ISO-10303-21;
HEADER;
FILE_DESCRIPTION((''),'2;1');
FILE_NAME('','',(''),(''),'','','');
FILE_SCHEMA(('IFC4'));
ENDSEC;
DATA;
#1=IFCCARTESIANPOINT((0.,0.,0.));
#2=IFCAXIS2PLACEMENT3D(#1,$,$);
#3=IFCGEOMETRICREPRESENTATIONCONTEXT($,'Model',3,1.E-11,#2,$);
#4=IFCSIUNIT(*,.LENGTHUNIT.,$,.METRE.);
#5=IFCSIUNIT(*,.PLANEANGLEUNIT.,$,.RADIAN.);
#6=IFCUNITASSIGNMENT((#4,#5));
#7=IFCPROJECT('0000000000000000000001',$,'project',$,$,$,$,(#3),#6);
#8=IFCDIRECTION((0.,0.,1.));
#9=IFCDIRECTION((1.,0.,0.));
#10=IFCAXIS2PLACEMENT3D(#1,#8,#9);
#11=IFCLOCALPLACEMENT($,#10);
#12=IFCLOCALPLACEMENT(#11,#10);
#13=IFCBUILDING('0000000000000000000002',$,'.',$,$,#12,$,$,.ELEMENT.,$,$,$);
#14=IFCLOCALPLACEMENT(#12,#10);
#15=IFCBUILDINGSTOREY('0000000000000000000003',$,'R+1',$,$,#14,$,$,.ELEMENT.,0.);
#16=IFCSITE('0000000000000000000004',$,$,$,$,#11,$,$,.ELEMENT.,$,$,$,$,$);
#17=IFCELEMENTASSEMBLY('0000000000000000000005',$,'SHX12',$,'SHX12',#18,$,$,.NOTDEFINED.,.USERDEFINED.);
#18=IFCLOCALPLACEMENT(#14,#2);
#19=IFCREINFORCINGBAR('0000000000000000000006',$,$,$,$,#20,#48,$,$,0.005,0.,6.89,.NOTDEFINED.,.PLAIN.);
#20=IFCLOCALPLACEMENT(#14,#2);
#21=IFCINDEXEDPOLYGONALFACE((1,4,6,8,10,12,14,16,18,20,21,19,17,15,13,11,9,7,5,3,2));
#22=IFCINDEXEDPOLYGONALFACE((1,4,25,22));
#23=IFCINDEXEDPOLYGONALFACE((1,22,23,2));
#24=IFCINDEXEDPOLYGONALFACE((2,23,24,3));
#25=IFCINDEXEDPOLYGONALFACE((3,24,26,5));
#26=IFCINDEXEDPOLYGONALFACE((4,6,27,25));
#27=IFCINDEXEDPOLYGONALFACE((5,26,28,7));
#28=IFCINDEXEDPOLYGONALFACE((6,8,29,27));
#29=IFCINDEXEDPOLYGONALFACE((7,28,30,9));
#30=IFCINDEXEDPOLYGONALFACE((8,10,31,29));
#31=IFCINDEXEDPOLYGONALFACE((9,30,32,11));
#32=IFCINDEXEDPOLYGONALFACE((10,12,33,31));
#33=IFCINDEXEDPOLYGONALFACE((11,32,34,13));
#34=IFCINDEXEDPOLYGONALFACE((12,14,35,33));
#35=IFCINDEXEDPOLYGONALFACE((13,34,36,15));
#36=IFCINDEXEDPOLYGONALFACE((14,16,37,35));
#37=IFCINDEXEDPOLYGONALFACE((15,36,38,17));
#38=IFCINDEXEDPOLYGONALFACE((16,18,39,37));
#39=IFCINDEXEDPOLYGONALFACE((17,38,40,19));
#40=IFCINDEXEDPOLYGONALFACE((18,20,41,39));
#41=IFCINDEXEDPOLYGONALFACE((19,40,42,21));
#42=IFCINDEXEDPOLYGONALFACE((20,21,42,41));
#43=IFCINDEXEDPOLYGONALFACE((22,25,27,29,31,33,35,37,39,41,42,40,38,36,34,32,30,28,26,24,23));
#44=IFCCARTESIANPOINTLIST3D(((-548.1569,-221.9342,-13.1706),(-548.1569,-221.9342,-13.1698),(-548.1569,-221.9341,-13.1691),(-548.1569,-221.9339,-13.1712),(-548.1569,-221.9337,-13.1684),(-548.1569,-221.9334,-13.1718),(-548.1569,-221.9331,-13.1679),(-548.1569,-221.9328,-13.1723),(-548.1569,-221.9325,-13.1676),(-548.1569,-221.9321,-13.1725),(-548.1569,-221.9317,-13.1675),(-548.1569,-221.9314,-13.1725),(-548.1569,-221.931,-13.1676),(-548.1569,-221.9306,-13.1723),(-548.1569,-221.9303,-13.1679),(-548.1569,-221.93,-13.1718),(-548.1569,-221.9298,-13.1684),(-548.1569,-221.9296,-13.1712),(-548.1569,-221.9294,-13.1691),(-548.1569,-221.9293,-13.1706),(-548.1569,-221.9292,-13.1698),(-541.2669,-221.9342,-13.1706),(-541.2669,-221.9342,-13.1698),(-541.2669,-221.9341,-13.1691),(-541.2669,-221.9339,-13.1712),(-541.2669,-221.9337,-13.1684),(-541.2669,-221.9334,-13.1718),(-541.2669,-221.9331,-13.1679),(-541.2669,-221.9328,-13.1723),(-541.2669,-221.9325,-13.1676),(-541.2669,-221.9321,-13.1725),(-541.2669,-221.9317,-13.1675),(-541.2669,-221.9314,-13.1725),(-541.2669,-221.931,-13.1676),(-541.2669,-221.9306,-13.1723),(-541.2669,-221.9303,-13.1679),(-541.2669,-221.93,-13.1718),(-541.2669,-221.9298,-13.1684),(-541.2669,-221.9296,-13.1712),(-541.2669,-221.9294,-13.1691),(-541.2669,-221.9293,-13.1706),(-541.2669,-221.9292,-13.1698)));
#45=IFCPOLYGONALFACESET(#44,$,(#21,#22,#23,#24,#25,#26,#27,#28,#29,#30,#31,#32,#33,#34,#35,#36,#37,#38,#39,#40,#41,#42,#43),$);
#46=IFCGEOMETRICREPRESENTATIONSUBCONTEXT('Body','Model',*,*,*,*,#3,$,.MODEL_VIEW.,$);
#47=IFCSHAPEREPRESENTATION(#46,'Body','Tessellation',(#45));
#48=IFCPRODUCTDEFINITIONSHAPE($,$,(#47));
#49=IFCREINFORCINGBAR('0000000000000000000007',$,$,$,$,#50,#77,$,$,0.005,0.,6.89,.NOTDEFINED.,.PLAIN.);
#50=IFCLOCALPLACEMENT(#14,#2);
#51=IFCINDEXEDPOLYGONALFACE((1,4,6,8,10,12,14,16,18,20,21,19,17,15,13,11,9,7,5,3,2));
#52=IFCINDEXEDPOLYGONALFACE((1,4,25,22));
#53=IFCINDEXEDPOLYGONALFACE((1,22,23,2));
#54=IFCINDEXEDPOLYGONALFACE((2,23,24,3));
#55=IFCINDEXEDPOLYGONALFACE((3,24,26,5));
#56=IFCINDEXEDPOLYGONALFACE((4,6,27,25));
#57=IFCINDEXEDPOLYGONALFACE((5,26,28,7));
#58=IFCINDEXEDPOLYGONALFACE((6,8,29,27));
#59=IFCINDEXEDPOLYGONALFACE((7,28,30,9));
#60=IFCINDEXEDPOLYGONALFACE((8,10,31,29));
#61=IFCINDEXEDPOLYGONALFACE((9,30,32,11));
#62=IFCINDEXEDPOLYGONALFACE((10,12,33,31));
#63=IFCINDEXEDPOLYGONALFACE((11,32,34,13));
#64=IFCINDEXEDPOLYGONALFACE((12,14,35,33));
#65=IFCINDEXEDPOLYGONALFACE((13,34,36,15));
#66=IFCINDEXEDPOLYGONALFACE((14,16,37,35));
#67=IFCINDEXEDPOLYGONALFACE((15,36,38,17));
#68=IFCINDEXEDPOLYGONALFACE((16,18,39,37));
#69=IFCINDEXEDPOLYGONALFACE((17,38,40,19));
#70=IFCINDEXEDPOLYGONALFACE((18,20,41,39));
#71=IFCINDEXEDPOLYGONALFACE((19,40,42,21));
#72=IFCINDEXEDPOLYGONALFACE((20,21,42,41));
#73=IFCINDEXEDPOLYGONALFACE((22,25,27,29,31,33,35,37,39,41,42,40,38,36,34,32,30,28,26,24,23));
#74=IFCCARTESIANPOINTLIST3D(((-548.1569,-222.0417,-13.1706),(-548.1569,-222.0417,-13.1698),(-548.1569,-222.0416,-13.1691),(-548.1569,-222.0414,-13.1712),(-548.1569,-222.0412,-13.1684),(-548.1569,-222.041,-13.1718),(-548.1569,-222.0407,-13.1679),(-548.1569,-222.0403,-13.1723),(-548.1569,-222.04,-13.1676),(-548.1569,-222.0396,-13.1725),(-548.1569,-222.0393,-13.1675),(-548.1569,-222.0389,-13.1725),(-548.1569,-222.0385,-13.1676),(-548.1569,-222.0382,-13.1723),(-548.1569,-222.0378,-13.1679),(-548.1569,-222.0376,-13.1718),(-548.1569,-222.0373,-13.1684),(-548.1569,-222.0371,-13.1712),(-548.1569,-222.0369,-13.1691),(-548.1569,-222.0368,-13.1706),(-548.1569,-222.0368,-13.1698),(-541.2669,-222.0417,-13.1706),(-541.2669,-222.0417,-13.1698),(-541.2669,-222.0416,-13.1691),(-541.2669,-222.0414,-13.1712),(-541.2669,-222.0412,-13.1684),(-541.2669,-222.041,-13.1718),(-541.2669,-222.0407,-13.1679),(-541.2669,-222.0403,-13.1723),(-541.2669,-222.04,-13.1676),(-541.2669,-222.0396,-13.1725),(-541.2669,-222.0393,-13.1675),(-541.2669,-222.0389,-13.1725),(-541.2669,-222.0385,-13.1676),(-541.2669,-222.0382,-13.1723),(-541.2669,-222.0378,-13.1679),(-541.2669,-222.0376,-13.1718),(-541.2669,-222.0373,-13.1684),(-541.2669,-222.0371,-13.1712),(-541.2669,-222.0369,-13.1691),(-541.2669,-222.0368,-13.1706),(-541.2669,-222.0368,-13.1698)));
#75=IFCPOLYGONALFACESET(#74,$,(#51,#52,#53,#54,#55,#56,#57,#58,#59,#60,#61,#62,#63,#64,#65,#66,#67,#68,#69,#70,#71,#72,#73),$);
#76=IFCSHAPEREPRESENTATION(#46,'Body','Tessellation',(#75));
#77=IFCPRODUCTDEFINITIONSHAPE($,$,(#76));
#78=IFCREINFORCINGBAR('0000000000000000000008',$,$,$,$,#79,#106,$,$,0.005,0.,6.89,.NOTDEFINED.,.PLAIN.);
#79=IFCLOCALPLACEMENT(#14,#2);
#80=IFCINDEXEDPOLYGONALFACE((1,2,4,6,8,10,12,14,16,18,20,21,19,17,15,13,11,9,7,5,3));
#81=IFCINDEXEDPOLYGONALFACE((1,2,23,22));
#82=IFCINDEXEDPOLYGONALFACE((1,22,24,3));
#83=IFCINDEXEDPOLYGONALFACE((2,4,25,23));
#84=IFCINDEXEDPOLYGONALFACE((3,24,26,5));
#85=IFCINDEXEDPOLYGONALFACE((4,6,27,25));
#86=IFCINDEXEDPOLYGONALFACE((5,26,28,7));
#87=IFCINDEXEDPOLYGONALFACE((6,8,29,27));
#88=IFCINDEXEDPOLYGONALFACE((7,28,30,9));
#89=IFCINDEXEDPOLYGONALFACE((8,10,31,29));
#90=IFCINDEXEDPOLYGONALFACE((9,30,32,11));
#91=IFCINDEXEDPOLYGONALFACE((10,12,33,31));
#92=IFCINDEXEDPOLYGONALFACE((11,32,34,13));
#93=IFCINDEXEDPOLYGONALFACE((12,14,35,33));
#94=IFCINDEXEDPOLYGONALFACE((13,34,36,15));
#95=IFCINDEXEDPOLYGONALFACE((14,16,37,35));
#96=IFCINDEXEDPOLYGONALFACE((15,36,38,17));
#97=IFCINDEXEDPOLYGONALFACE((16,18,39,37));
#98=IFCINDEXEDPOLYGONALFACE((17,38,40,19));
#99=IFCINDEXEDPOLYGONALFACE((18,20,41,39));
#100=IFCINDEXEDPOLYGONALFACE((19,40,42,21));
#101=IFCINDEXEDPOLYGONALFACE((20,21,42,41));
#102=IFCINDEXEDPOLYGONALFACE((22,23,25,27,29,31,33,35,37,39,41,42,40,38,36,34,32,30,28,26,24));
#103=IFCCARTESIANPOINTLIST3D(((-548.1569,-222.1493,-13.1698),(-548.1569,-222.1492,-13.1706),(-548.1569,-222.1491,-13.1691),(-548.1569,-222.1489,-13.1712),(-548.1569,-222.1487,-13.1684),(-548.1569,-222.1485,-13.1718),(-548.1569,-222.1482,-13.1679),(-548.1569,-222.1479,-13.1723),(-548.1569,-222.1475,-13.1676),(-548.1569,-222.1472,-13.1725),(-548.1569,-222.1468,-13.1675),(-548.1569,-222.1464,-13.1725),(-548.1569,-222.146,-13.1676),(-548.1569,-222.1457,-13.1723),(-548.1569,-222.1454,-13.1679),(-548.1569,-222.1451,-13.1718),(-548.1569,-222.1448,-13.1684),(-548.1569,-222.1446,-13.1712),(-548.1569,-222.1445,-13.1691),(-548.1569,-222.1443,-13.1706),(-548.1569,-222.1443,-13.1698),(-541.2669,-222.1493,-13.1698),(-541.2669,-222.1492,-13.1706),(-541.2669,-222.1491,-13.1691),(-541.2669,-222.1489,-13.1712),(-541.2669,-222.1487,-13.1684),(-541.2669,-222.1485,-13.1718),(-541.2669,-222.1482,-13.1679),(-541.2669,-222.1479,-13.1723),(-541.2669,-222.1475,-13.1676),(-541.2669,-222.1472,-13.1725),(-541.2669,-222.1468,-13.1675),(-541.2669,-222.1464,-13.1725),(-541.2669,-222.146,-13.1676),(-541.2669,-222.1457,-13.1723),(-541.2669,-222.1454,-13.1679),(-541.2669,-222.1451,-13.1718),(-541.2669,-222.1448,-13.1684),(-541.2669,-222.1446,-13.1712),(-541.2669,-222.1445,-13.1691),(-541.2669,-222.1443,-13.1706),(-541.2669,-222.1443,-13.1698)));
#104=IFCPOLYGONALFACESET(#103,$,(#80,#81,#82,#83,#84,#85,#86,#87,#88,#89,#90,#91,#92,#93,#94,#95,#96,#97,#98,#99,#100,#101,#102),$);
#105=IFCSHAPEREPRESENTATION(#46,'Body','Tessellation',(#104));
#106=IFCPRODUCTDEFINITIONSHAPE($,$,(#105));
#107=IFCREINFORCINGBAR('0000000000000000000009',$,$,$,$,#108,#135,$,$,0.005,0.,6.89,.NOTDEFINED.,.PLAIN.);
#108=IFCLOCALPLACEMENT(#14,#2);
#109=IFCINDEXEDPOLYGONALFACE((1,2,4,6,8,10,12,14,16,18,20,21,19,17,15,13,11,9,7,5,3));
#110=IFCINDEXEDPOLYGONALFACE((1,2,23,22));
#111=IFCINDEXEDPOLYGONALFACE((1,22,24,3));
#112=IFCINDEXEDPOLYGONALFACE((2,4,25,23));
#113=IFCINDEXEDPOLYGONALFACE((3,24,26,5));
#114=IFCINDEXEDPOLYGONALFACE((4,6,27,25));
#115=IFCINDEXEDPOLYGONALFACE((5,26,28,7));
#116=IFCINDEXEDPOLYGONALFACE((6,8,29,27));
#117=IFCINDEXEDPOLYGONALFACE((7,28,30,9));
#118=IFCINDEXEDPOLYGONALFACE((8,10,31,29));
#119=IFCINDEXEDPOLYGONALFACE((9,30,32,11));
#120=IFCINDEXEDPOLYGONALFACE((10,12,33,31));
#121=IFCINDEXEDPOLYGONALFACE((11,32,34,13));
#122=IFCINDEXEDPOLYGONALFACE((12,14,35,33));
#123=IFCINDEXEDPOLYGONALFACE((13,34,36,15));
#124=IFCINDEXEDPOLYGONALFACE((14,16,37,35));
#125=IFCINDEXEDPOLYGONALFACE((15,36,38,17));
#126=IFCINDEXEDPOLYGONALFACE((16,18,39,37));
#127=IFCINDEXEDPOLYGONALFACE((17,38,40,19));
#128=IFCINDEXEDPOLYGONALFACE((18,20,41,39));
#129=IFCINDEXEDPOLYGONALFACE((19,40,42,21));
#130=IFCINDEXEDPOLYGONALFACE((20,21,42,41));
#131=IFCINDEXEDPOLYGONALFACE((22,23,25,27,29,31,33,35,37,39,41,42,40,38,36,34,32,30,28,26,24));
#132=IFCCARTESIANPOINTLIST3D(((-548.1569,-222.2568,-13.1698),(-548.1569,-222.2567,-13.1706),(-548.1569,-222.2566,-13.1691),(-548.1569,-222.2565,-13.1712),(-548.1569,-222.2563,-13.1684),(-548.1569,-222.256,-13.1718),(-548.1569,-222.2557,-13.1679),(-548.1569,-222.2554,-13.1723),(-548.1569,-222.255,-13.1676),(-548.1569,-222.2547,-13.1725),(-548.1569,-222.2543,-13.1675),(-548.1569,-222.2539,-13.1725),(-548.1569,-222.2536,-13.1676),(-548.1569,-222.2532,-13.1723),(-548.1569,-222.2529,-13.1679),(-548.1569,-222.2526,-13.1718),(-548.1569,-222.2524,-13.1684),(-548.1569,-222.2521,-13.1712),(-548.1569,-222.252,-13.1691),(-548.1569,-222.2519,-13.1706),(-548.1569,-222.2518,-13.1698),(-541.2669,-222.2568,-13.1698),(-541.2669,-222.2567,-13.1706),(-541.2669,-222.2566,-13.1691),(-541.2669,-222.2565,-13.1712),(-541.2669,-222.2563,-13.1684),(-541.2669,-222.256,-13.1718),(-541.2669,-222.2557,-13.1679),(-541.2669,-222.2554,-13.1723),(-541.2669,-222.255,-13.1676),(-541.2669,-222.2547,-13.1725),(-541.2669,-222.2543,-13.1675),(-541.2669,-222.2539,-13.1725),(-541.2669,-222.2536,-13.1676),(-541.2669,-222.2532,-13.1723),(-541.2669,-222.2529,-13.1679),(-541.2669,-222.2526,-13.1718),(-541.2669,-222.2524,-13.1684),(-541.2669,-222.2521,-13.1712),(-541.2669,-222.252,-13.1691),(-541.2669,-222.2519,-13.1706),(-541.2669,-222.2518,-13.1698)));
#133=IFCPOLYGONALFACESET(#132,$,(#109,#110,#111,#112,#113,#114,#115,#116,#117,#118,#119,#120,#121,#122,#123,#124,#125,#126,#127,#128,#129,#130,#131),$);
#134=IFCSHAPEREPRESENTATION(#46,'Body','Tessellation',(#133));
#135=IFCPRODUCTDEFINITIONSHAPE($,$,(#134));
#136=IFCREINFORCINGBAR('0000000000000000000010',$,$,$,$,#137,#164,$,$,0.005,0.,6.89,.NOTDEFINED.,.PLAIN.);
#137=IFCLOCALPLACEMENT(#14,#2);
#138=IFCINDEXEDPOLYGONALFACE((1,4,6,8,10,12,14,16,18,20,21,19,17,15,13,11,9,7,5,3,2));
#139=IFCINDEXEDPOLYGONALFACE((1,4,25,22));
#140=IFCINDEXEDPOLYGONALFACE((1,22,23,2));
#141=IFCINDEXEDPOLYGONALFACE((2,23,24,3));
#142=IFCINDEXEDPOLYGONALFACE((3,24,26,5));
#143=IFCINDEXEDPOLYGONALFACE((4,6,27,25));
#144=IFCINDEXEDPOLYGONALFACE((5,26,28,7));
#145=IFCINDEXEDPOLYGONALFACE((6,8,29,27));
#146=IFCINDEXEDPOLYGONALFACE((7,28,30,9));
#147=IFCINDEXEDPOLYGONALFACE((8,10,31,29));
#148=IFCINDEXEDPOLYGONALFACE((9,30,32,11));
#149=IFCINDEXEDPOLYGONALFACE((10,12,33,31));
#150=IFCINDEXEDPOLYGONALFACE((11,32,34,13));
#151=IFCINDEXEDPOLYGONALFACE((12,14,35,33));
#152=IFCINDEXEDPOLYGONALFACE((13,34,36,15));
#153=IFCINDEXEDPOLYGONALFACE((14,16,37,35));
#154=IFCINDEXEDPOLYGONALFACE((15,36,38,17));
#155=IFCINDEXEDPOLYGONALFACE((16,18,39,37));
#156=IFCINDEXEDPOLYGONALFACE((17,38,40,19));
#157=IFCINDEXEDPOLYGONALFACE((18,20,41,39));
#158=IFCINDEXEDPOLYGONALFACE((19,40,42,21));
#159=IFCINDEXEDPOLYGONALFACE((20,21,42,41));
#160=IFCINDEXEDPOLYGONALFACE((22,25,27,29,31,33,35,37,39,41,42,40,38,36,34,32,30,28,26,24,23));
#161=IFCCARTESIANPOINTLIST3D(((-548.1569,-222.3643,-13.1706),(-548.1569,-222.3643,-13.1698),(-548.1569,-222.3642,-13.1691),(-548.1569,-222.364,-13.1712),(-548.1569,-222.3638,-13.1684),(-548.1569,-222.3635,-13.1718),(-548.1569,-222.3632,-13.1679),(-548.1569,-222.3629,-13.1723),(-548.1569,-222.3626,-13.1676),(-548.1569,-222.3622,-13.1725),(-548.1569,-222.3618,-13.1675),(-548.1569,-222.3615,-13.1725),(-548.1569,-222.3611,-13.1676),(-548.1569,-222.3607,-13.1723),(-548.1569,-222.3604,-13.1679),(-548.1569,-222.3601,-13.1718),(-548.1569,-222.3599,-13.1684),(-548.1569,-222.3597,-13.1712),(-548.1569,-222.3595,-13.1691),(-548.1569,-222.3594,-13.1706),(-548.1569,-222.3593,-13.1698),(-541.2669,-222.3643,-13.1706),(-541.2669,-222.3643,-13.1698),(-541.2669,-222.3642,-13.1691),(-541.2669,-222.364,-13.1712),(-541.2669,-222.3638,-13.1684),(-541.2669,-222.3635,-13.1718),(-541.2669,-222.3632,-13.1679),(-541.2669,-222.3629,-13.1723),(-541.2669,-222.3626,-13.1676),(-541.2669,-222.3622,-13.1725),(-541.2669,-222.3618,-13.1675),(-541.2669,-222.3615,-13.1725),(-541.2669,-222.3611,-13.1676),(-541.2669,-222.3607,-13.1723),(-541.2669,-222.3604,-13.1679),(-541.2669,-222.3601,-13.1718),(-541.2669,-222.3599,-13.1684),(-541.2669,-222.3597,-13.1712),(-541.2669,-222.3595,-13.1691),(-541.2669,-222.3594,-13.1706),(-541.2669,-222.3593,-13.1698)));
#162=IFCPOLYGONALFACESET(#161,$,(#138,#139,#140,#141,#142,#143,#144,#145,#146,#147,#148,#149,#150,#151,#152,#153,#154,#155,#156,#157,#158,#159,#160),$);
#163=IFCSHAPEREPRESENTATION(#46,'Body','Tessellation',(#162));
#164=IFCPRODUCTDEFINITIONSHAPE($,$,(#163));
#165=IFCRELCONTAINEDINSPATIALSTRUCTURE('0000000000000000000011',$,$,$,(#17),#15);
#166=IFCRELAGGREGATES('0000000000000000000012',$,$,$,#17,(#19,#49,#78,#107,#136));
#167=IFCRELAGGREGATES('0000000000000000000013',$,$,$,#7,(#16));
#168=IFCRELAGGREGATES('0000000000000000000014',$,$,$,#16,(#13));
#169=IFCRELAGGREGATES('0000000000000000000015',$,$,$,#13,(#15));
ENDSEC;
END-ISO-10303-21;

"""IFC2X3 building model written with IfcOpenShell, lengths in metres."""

from ifc_helpers import new_model, entity, si_unit, origin, origin_with_axes, place, context, subcontext, project, spatial, shape, element, aggregate, save


model = new_model("IFC2X3")

# Units and contexts
model_context = context("Model", 3, precision=1e-11, world=origin())
body_context = subcontext(model_context, "Body", "Model", "MODEL_VIEW")
ifc_project = project(units=[si_unit("LENGTHUNIT", "METRE"), si_unit("PLANEANGLEUNIT", "RADIAN")], contexts=[model_context])

# Site, building, storey
site_placement = place(None, origin_with_axes())
site = spatial("IfcSite", under=ifc_project, at=site_placement, CompositionType="ELEMENT")
building_placement = place(site_placement, origin_with_axes())
building = spatial("IfcBuilding", under=site, at=building_placement, Name=".", CompositionType="ELEMENT")
storey_placement = place(building_placement, origin_with_axes())
storey = spatial("IfcBuildingStorey", under=building, at=storey_placement, Name="R+1", CompositionType="ELEMENT", Elevation=0.0)

# Element assembly, reinforcing bars
assembly_1_placement = place(storey_placement, origin_with_axes())
assembly_1 = element("IfcElementAssembly", 1, at=assembly_1_placement, inside=storey, Name="SHX12", ObjectType="SHX12", AssemblyPlace="NOTDEFINED", PredefinedType="USERDEFINED")
reinforcing_bar_1_placement = place(assembly_1_placement, origin_with_axes())
reinforcing_bar_1 = element("IfcReinforcingBar", 2, at=reinforcing_bar_1_placement, BarLength=6.89, BarRole="NOTDEFINED", BarSurface="PLAIN", CrossSectionArea=0.0, NominalDiameter=0.005, shapes=[
    shape(body_context, "Body", "AdvancedSweptSolid", [entity("IfcSweptDiskSolid", entity("IfcPolyline", [entity("IfcCartesianPoint", [541.2669, 221.9317, 13.17]), entity("IfcCartesianPoint", [548.1569, 221.9317, 13.17])]), 0.0025, None, 0.0, 6.89)]),
    shape(body_context, "Body", "AdvancedSweptSolid", [entity("IfcSweptDiskSolid", entity("IfcPolyline", [entity("IfcCartesianPoint", [541.2669, 221.9317, 13.17]), entity("IfcCartesianPoint", [548.1569, 221.9317, 13.17])]), 0.0025, None, 0.0, 6.89)]),
])
reinforcing_bar_2_placement = place(assembly_1_placement, origin_with_axes())
reinforcing_bar_2 = element("IfcReinforcingBar", 3, at=reinforcing_bar_2_placement, BarLength=6.89, BarRole="NOTDEFINED", BarSurface="PLAIN", CrossSectionArea=0.0, NominalDiameter=0.005, shapes=[
    shape(body_context, "Body", "AdvancedSweptSolid", [entity("IfcSweptDiskSolid", entity("IfcPolyline", [entity("IfcCartesianPoint", [541.2669, 222.0393, 13.17]), entity("IfcCartesianPoint", [548.1569, 222.0393, 13.17])]), 0.0025, None, 0.0, 6.89)]),
    shape(body_context, "Body", "AdvancedSweptSolid", [entity("IfcSweptDiskSolid", entity("IfcPolyline", [entity("IfcCartesianPoint", [541.2669, 222.0393, 13.17]), entity("IfcCartesianPoint", [548.1569, 222.0393, 13.17])]), 0.0025, None, 0.0, 6.89)]),
])
reinforcing_bar_3_placement = place(assembly_1_placement, origin_with_axes())
reinforcing_bar_3 = element("IfcReinforcingBar", 4, at=reinforcing_bar_3_placement, BarLength=6.89, BarRole="NOTDEFINED", BarSurface="PLAIN", CrossSectionArea=0.0, NominalDiameter=0.005, shapes=[
    shape(body_context, "Body", "AdvancedSweptSolid", [entity("IfcSweptDiskSolid", entity("IfcPolyline", [entity("IfcCartesianPoint", [541.2669, 222.1468, 13.17]), entity("IfcCartesianPoint", [548.1569, 222.1468, 13.17])]), 0.0025, None, 0.0, 6.89)]),
    shape(body_context, "Body", "AdvancedSweptSolid", [entity("IfcSweptDiskSolid", entity("IfcPolyline", [entity("IfcCartesianPoint", [541.2669, 222.1468, 13.17]), entity("IfcCartesianPoint", [548.1569, 222.1468, 13.17])]), 0.0025, None, 0.0, 6.89)]),
])
reinforcing_bar_4_placement = place(assembly_1_placement, origin_with_axes())
reinforcing_bar_4 = element("IfcReinforcingBar", 5, at=reinforcing_bar_4_placement, BarLength=6.89, BarRole="NOTDEFINED", BarSurface="PLAIN", CrossSectionArea=0.0, NominalDiameter=0.005, shapes=[
    shape(body_context, "Body", "AdvancedSweptSolid", [entity("IfcSweptDiskSolid", entity("IfcPolyline", [entity("IfcCartesianPoint", [541.2669, 222.2543, 13.17]), entity("IfcCartesianPoint", [548.1569, 222.2543, 13.17])]), 0.0025, None, 0.0, 6.89)]),
    shape(body_context, "Body", "AdvancedSweptSolid", [entity("IfcSweptDiskSolid", entity("IfcPolyline", [entity("IfcCartesianPoint", [541.2669, 222.2543, 13.17]), entity("IfcCartesianPoint", [548.1569, 222.2543, 13.17])]), 0.0025, None, 0.0, 6.89)]),
])
reinforcing_bar_5_placement = place(assembly_1_placement, origin_with_axes())
reinforcing_bar_5 = element("IfcReinforcingBar", 6, at=reinforcing_bar_5_placement, BarLength=6.89, BarRole="NOTDEFINED", BarSurface="PLAIN", CrossSectionArea=0.0, NominalDiameter=0.005, shapes=[
    shape(body_context, "Body", "AdvancedSweptSolid", [entity("IfcSweptDiskSolid", entity("IfcPolyline", [entity("IfcCartesianPoint", [541.2669, 222.3618, 13.17]), entity("IfcCartesianPoint", [548.1569, 222.3618, 13.17])]), 0.0025, None, 0.0, 6.89)]),
    shape(body_context, "Body", "AdvancedSweptSolid", [entity("IfcSweptDiskSolid", entity("IfcPolyline", [entity("IfcCartesianPoint", [541.2669, 222.3618, 13.17]), entity("IfcCartesianPoint", [548.1569, 222.3618, 13.17])]), 0.0025, None, 0.0, 6.89)]),
])
aggregate(assembly_1, [reinforcing_bar_1, reinforcing_bar_2, reinforcing_bar_3, reinforcing_bar_4, reinforcing_bar_5])

save(model, "model.ifc")
